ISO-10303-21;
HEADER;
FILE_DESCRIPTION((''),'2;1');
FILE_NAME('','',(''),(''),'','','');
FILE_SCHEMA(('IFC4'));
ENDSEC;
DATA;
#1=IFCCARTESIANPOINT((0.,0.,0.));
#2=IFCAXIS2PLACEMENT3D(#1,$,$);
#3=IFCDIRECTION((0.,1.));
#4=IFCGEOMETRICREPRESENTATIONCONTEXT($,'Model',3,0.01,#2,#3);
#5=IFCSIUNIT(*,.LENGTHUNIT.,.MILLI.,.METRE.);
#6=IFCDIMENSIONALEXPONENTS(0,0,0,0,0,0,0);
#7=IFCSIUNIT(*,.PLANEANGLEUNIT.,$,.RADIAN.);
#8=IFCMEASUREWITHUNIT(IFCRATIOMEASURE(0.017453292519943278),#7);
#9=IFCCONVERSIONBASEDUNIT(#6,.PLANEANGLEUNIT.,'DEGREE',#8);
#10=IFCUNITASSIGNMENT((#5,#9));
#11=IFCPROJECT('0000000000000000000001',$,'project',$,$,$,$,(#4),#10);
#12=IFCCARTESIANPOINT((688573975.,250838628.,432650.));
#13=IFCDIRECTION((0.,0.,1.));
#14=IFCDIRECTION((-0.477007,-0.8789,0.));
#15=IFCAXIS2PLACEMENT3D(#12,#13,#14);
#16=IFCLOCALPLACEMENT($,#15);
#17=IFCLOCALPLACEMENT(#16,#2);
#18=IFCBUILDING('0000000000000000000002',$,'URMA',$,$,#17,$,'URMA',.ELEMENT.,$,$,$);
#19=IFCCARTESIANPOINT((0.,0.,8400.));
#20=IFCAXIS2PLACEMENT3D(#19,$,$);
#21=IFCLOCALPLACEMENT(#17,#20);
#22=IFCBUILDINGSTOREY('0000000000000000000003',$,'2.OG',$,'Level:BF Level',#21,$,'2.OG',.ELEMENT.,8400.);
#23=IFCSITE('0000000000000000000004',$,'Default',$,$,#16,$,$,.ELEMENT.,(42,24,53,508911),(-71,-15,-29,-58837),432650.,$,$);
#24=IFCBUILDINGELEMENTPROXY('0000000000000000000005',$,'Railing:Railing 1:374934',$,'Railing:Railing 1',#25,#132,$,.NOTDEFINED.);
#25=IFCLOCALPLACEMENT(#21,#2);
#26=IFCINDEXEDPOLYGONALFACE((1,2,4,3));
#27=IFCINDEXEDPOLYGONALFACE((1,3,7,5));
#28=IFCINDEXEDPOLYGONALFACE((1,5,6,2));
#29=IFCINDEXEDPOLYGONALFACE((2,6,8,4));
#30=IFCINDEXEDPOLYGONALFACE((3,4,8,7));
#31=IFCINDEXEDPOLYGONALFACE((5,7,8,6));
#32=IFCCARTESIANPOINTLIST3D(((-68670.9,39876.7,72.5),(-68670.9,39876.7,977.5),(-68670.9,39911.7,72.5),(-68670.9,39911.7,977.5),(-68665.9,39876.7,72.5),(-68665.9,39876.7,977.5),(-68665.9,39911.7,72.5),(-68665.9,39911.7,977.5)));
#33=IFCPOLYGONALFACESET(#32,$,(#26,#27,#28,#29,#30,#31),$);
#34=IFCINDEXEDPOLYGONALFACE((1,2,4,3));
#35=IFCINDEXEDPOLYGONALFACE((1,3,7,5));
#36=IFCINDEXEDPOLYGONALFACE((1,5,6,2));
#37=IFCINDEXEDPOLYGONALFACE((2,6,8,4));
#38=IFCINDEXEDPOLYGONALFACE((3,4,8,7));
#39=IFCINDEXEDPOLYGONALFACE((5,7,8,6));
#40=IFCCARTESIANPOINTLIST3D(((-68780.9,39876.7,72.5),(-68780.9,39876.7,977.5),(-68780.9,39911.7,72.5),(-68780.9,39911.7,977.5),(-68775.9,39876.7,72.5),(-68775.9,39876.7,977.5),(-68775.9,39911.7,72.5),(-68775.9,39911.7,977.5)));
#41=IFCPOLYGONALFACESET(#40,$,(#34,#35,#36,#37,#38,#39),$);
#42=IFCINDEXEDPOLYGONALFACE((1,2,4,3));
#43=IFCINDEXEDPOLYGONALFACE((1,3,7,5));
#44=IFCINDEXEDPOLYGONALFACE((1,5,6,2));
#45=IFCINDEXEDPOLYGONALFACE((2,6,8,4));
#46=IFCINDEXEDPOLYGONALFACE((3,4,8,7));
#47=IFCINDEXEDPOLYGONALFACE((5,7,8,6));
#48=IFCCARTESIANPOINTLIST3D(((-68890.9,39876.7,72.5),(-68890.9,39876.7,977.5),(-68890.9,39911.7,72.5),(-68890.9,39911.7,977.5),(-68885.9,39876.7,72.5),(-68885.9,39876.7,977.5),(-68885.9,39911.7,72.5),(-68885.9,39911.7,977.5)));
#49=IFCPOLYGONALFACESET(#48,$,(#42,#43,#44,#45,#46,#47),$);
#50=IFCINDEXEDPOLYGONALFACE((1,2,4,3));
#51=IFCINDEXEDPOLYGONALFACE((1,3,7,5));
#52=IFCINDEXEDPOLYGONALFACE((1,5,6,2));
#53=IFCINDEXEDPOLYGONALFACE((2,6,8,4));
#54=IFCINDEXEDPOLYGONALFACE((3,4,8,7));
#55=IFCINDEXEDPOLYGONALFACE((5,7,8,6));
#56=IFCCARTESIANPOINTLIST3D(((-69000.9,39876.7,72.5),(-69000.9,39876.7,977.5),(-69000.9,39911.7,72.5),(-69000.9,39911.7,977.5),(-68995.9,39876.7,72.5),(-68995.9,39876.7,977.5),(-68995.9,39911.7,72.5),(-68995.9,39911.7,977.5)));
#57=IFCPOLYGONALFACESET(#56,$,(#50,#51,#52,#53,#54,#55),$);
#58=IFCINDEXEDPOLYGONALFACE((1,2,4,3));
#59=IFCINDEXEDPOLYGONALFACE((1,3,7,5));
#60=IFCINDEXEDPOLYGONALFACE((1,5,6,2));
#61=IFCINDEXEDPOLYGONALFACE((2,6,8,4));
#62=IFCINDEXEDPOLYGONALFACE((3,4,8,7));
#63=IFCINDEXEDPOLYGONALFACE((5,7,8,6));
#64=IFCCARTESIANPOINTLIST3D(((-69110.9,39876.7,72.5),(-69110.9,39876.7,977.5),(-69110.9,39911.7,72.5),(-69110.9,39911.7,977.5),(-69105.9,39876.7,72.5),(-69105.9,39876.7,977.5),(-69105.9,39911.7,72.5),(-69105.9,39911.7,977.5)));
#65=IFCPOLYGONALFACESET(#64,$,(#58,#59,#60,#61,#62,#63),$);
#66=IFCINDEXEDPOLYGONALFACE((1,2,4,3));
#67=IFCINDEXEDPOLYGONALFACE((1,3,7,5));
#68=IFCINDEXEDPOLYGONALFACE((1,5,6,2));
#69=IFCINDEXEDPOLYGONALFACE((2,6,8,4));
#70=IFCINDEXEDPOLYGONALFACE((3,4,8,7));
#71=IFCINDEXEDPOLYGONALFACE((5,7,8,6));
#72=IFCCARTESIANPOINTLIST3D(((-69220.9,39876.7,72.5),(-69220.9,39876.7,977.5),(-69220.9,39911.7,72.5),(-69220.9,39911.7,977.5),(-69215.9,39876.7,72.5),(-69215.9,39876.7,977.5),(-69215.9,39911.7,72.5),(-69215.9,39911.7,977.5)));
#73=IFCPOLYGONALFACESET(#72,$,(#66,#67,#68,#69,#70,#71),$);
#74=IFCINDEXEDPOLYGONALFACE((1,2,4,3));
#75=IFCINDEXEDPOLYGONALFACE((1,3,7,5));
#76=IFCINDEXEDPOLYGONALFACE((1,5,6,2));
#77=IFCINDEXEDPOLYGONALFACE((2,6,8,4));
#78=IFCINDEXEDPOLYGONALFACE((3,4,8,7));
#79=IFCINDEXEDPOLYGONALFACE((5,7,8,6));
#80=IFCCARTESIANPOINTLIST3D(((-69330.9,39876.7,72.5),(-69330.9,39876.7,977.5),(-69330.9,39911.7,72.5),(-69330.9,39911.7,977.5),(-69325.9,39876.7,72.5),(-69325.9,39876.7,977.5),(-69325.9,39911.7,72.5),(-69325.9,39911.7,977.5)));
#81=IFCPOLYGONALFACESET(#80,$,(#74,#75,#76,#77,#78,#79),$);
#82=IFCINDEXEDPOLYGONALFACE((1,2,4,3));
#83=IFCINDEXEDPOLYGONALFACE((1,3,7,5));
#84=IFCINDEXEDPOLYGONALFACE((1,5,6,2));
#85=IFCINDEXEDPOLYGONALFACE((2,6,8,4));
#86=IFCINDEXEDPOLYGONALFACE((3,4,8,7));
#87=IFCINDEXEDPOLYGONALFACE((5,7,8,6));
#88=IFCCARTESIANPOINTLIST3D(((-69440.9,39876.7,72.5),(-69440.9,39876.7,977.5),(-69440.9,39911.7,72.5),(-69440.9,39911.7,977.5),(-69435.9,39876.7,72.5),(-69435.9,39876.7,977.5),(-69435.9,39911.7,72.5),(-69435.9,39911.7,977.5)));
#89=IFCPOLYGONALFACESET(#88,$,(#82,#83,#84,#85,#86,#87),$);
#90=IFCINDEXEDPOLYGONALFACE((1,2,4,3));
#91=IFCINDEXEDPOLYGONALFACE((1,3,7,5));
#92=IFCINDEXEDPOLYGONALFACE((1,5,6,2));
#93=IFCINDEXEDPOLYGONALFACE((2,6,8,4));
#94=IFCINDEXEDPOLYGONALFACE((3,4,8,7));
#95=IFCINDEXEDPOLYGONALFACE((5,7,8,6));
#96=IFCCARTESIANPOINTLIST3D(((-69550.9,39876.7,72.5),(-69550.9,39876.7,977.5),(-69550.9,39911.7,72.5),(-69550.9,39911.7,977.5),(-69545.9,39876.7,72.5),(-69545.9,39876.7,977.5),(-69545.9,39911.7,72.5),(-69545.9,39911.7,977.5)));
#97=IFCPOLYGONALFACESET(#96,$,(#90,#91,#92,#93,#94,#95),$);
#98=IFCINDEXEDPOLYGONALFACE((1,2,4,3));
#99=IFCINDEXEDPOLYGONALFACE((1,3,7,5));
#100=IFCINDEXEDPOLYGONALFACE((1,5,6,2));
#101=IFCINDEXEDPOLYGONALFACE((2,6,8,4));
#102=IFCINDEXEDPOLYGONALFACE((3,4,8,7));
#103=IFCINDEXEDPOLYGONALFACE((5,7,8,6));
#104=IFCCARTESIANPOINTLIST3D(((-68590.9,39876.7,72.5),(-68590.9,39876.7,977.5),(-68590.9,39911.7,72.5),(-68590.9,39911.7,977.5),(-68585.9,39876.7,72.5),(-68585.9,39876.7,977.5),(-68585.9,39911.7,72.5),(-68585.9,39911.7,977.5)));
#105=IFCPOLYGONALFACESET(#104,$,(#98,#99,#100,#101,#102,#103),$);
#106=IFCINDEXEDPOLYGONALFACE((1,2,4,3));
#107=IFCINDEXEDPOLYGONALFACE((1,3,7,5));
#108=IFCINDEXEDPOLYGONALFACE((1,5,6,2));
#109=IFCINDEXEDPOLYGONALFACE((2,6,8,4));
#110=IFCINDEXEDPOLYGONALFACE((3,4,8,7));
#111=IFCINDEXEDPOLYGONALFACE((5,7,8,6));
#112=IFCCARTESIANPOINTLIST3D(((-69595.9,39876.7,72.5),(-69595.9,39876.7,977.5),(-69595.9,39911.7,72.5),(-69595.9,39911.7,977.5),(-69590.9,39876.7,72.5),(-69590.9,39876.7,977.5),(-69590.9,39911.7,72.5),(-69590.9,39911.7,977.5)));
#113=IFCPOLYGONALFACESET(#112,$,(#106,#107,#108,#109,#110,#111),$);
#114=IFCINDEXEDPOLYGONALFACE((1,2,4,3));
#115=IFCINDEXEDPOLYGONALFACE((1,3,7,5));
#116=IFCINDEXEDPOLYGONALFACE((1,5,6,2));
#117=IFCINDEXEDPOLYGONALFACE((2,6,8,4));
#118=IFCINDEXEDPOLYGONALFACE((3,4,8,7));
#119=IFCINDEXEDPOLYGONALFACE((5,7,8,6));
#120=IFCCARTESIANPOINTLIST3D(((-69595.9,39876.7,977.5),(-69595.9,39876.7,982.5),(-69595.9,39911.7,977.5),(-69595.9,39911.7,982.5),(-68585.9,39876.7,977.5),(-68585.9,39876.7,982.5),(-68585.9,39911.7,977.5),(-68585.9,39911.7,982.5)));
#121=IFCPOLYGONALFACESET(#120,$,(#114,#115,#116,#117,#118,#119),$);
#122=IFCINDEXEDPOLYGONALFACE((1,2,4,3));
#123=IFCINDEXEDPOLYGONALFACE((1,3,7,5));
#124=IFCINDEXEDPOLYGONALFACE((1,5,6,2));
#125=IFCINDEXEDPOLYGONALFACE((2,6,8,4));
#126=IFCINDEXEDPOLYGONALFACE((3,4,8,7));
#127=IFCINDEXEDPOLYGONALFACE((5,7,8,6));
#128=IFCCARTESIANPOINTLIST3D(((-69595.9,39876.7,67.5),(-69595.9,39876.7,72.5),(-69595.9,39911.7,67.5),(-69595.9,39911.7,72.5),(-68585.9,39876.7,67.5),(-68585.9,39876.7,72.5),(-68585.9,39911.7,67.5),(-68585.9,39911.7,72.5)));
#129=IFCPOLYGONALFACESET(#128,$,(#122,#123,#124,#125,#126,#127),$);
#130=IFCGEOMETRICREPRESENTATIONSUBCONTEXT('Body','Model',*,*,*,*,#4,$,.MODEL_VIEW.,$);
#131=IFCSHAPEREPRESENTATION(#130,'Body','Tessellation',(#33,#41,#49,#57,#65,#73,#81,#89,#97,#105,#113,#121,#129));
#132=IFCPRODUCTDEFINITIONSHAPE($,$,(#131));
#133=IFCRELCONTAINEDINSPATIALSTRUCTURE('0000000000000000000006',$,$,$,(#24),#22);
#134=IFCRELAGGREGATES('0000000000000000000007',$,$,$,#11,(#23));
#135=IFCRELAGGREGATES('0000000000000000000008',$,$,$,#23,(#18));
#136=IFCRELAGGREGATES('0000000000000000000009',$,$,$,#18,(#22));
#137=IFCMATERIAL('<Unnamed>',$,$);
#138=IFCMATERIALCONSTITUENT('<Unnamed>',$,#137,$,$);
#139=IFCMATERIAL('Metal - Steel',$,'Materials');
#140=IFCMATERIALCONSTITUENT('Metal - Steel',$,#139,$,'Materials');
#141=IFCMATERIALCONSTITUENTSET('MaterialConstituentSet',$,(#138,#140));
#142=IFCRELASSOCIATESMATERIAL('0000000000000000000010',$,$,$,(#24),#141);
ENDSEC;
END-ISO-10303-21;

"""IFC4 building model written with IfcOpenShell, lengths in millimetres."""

from ifc_helpers import new_model, entity, si_unit, converted_unit, direction, frame, origin, place, context, subcontext, project, spatial, indexed_curve, outline, extrude, material, constituent, constituent_set, element, save


model = new_model("IFC4")

# Units and contexts
model_context = context("Model", 3, precision=0.01, world=origin(), true_north=direction((0.0, 1.0)))
body_context = subcontext(model_context, "Body", "Model", "MODEL_VIEW")
ifc_project = project(units=[si_unit("LENGTHUNIT", "METRE", prefix="MILLI"), converted_unit("PLANEANGLEUNIT", "DEGREE", entity("IfcRatioMeasure", 0.017453292519943278), si_unit("PLANEANGLEUNIT", "RADIAN"), dimensions=[0, 0, 0, 0, 0, 0, 0])], contexts=[model_context])

# Site, building, storey
site_placement = place(None, frame((688573975.0, 250838628.0, 432650.0), z_axis=(0.0, 0.0, 1.0), x_axis=(-0.477007, -0.8789, 0.0)))
site = spatial("IfcSite", under=ifc_project, at=site_placement, Name="Default", CompositionType="ELEMENT", RefLatitude=(42, 24, 53, 508911), RefLongitude=(-71, -15, -29, -58837), RefElevation=432650.0)
building_placement = place(site_placement, origin())
building = spatial("IfcBuilding", under=site, at=building_placement, Name="URMA", LongName="URMA", CompositionType="ELEMENT")
storey_placement = place(building_placement, frame((0.0, 0.0, 8400.0)))
storey = spatial("IfcBuildingStorey", under=building, at=storey_placement, Name="2.OG", ObjectType="Level:BF Level", LongName="2.OG", CompositionType="ELEMENT", Elevation=8400.0)

# Building element proxy
ifc_material_1 = material(Name="<Unnamed>")
ifc_material_2 = material(Name="Metal - Steel", Category="Materials")
ifc_constituent_1 = constituent(ifc_material_1, Name="<Unnamed>")
ifc_constituent_2 = constituent(ifc_material_2, Name="Metal - Steel", Category="Materials")
ifc_constituent_set_1 = constituent_set(constituents=[ifc_constituent_1, ifc_constituent_2], Name="MaterialConstituentSet")
proxy_1_placement = place(storey_placement, origin())
element("IfcBuildingElementProxy", 1, at=proxy_1_placement, inside=storey, material=ifc_constituent_set_1, Name="Railing:Railing 1:374934", ObjectType="Railing:Railing 1", PredefinedType="NOTDEFINED", context=body_context, shape_type="SweptSolid", body=[
    extrude(outline(indexed_curve([(-17.5, -2.5), (17.5, -2.5), (17.5, 2.5), (-17.5, 2.5), (-17.5, -2.5)], self_intersect=False)), frame((-68668.4, 39894.2, 72.5), z_axis=(0.0, 0.0, 1.0), x_axis=(0.0, 1.0, 0.0)), (0.0, 0.0, 1.0), 905.0),
    extrude(outline(indexed_curve([(-17.5, -2.5), (17.5, -2.5), (17.5, 2.5), (-17.5, 2.5), (-17.5, -2.5)], self_intersect=False)), frame((-68778.4, 39894.2, 72.5), z_axis=(0.0, 0.0, 1.0), x_axis=(0.0, 1.0, 0.0)), (0.0, 0.0, 1.0), 905.0),
    extrude(outline(indexed_curve([(-17.5, -2.5), (17.5, -2.5), (17.5, 2.5), (-17.5, 2.5), (-17.5, -2.5)], self_intersect=False)), frame((-68888.4, 39894.2, 72.5), z_axis=(0.0, 0.0, 1.0), x_axis=(0.0, 1.0, 0.0)), (0.0, 0.0, 1.0), 905.0),
    extrude(outline(indexed_curve([(-17.5, -2.5), (17.5, -2.5), (17.5, 2.5), (-17.5, 2.5), (-17.5, -2.5)], self_intersect=False)), frame((-68998.4, 39894.2, 72.5), z_axis=(0.0, 0.0, 1.0), x_axis=(0.0, 1.0, 0.0)), (0.0, 0.0, 1.0), 905.0),
    extrude(outline(indexed_curve([(-17.5, -2.5), (17.5, -2.5), (17.5, 2.5), (-17.5, 2.5), (-17.5, -2.5)], self_intersect=False)), frame((-69108.4, 39894.2, 72.5), z_axis=(0.0, 0.0, 1.0), x_axis=(0.0, 1.0, 0.0)), (0.0, 0.0, 1.0), 905.0),
    extrude(outline(indexed_curve([(-17.5, -2.5), (17.5, -2.5), (17.5, 2.5), (-17.5, 2.5), (-17.5, -2.5)], self_intersect=False)), frame((-69218.4, 39894.2, 72.5), z_axis=(0.0, 0.0, 1.0), x_axis=(0.0, 1.0, 0.0)), (0.0, 0.0, 1.0), 905.0),
    extrude(outline(indexed_curve([(-17.5, -2.5), (17.5, -2.5), (17.5, 2.5), (-17.5, 2.5), (-17.5, -2.5)], self_intersect=False)), frame((-69328.4, 39894.2, 72.5), z_axis=(0.0, 0.0, 1.0), x_axis=(0.0, 1.0, 0.0)), (0.0, 0.0, 1.0), 905.0),
    extrude(outline(indexed_curve([(-17.5, -2.5), (17.5, -2.5), (17.5, 2.5), (-17.5, 2.5), (-17.5, -2.5)], self_intersect=False)), frame((-69438.4, 39894.2, 72.5), z_axis=(0.0, 0.0, 1.0), x_axis=(0.0, 1.0, 0.0)), (0.0, 0.0, 1.0), 905.0),
    extrude(outline(indexed_curve([(-17.5, -2.5), (17.5, -2.5), (17.5, 2.5), (-17.5, 2.5), (-17.5, -2.5)], self_intersect=False)), frame((-69548.4, 39894.2, 72.5), z_axis=(0.0, 0.0, 1.0), x_axis=(0.0, 1.0, 0.0)), (0.0, 0.0, 1.0), 905.0),
    extrude(outline(indexed_curve([(-17.5, -2.5), (17.5, -2.5), (17.5, 2.5), (-17.5, 2.5), (-17.5, -2.5)], self_intersect=False)), frame((-68588.4, 39894.2, 72.5), z_axis=(0.0, 0.0, 1.0), x_axis=(0.0, 1.0, 0.0)), (0.0, 0.0, 1.0), 905.0),
    extrude(outline(indexed_curve([(-17.5, -2.5), (17.5, -2.5), (17.5, 2.5), (-17.5, 2.5), (-17.5, -2.5)], self_intersect=False)), frame((-69593.4, 39894.2, 72.5), z_axis=(0.0, 0.0, 1.0), x_axis=(0.0, 1.0, 0.0)), (0.0, 0.0, 1.0), 905.0),
    extrude(outline(indexed_curve([(-505.0, -17.5), (505.0, -17.5), (505.0, 17.5), (-505.0, 17.5), (-505.0, -17.5)], self_intersect=False)), frame((-69090.9, 39894.2, 977.5)), (0.0, 0.0, 1.0), 5.0),
    extrude(outline(indexed_curve([(-505.0, -17.5), (505.0, -17.5), (505.0, 17.5), (-505.0, 17.5), (-505.0, -17.5)], self_intersect=False)), frame((-69090.9, 39894.2, 67.5)), (0.0, 0.0, 1.0), 5.0),
])

save(model, "model.ifc")
